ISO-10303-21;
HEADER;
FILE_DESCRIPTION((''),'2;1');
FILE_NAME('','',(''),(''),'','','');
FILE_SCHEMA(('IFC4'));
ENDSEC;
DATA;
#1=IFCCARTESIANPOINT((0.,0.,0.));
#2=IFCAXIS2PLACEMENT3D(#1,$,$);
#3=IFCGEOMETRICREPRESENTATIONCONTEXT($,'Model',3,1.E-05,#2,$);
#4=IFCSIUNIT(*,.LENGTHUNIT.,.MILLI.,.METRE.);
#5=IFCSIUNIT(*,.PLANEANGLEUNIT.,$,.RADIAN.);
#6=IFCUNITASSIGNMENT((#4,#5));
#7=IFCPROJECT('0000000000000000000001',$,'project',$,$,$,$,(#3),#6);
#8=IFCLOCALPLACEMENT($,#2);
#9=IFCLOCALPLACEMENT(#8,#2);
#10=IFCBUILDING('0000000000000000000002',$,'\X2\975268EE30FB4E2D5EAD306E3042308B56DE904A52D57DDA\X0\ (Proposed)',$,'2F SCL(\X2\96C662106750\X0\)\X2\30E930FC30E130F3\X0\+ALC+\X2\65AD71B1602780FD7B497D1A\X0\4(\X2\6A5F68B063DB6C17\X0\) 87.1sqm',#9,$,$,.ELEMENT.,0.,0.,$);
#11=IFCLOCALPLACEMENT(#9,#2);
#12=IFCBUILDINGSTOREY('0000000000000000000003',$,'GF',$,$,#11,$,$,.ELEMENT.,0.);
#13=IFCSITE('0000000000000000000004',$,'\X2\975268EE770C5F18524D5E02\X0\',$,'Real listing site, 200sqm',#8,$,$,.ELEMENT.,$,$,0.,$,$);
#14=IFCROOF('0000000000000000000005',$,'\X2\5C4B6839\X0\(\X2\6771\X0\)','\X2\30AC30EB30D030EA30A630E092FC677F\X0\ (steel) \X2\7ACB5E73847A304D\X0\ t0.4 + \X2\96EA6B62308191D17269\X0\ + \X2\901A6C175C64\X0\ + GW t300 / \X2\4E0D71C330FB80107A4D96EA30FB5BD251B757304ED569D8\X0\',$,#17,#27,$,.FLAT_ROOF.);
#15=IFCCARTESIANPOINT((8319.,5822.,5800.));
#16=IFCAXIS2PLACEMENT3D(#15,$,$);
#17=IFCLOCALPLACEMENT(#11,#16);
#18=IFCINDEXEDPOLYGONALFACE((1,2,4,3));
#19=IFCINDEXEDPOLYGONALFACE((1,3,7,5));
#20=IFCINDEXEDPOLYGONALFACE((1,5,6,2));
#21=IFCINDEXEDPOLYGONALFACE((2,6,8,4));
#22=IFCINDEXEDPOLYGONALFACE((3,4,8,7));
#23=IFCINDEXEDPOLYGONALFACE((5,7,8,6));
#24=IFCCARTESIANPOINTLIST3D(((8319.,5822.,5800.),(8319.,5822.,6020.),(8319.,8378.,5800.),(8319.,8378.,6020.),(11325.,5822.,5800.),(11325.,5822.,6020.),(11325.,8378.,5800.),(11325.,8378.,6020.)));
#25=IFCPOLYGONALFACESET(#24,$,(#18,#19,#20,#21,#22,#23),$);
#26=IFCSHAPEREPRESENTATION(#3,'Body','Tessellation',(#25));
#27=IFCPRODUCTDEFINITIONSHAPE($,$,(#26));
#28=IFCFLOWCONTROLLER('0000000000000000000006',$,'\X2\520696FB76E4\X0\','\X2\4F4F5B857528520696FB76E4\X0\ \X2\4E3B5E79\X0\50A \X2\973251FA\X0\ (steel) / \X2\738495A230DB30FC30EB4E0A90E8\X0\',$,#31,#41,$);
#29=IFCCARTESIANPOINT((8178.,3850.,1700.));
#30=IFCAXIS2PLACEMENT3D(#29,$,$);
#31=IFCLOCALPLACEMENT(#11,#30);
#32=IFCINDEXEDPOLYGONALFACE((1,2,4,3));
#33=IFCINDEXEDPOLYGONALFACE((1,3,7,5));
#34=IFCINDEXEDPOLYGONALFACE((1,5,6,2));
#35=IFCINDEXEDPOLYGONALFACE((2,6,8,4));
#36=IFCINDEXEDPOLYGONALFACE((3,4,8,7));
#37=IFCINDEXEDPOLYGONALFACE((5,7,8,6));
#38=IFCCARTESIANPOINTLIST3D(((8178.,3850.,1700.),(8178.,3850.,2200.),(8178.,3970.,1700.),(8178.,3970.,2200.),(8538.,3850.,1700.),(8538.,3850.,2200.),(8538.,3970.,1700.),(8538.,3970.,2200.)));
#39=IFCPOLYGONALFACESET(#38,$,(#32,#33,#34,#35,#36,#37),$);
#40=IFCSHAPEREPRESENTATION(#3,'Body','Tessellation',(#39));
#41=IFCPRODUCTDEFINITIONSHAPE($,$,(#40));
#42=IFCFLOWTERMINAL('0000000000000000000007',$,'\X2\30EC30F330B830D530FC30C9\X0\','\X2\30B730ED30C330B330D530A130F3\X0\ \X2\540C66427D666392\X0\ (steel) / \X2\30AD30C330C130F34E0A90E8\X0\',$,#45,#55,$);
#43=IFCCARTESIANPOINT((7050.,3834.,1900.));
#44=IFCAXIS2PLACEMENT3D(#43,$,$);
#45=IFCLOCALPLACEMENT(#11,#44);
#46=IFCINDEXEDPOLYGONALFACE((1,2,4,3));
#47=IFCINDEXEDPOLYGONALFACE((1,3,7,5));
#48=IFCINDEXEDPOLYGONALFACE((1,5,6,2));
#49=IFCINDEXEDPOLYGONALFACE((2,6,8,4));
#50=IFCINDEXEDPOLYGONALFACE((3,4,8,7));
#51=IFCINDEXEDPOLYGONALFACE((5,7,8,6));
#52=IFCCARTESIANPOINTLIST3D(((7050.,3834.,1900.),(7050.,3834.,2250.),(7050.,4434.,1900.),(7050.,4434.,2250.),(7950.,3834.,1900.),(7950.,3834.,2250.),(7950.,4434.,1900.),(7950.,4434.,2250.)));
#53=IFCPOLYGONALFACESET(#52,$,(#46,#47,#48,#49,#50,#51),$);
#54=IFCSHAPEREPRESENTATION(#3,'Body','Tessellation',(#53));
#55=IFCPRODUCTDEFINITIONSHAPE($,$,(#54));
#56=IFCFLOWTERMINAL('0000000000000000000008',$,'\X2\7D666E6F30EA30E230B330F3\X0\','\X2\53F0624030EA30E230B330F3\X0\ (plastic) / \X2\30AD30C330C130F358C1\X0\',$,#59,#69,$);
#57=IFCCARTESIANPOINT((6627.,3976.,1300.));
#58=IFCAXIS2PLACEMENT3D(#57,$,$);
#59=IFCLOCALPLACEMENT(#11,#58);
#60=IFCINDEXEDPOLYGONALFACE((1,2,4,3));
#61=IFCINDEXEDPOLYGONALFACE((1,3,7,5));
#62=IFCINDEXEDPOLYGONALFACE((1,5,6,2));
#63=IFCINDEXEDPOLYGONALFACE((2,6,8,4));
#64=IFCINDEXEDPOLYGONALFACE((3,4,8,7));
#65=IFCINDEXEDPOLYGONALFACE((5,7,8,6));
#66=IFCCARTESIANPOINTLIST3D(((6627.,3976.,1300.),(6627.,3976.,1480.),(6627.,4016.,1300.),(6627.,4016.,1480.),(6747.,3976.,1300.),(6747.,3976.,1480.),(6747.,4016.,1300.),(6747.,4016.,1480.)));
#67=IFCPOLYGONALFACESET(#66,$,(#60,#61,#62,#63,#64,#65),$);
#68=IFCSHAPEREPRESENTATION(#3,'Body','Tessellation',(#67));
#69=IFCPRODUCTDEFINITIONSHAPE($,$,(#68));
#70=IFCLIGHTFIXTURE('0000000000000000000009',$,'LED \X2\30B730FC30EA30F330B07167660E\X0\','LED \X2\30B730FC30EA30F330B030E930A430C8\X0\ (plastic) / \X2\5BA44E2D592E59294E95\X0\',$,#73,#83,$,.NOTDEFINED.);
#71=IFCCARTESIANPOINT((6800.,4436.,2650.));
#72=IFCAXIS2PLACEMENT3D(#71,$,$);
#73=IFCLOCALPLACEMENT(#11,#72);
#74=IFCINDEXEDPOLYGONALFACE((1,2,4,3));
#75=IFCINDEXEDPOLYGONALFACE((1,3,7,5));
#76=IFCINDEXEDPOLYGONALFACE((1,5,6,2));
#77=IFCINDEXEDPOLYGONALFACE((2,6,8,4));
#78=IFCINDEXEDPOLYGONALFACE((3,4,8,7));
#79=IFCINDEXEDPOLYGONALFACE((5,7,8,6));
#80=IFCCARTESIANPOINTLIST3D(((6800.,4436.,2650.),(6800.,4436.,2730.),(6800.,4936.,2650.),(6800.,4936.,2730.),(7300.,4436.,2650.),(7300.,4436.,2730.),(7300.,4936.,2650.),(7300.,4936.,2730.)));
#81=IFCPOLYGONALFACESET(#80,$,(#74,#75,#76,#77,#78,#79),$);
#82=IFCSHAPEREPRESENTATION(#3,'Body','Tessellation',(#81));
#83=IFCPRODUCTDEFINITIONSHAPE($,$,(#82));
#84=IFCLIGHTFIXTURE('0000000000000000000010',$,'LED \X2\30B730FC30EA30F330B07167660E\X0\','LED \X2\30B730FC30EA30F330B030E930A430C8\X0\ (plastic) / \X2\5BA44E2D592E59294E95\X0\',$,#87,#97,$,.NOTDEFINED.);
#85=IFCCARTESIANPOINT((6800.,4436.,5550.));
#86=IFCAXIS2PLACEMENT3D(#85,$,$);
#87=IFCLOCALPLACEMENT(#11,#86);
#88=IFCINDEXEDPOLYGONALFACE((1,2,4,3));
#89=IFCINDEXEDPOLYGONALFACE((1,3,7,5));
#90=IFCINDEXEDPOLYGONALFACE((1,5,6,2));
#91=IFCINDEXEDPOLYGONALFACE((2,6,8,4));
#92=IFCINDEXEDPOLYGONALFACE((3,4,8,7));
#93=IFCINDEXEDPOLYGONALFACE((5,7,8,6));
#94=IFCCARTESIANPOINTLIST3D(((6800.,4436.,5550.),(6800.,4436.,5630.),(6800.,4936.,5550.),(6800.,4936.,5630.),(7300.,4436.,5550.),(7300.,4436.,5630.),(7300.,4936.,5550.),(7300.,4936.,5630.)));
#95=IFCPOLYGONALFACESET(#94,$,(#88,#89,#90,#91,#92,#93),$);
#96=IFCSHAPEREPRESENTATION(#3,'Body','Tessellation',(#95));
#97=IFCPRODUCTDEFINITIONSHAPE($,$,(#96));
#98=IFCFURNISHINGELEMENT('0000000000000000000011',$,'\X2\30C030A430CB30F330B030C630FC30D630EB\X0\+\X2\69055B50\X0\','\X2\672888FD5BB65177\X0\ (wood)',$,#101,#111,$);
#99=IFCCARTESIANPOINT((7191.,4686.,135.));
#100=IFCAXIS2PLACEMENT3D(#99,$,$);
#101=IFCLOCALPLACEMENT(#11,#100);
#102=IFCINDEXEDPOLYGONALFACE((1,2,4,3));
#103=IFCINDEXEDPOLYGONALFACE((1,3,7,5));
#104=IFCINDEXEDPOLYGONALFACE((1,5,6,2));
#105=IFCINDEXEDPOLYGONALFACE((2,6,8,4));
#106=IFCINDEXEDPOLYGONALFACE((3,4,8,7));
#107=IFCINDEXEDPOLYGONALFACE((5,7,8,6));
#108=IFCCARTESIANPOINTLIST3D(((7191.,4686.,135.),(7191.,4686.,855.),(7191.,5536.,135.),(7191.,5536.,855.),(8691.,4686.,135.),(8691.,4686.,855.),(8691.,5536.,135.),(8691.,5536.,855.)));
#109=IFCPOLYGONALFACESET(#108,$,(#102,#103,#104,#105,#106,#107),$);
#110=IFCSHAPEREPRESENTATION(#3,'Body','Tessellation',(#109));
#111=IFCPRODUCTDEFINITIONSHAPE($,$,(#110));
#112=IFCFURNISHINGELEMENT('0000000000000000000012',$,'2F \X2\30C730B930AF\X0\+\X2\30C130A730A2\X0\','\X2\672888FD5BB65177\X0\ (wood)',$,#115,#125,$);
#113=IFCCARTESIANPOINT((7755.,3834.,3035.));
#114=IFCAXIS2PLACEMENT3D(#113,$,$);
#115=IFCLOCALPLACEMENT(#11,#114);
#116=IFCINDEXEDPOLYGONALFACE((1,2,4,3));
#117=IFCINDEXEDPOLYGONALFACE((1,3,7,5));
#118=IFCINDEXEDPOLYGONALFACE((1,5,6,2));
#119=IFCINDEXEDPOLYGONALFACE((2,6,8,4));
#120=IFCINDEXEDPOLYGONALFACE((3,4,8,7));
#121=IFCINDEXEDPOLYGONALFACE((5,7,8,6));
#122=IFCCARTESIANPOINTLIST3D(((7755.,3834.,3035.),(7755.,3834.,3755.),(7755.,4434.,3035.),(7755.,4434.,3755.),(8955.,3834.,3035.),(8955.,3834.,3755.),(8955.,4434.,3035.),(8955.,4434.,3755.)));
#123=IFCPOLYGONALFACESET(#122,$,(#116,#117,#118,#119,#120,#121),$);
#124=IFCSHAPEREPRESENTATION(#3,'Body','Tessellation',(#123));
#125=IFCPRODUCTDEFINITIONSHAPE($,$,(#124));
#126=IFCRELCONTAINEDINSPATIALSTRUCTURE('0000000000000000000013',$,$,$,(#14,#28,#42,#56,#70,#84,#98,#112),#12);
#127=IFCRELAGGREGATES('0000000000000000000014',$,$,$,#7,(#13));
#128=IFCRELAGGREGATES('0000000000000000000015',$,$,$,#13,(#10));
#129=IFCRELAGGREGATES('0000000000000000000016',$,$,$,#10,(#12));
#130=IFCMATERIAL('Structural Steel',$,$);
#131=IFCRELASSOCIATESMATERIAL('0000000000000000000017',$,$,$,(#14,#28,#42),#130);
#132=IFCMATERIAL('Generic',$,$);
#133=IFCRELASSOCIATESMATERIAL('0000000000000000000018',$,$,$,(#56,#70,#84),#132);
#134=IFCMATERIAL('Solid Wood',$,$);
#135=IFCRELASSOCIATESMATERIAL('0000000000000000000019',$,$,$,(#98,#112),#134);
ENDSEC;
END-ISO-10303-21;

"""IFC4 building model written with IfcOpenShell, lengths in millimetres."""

from ifc_helpers import new_model, si_unit, frame, frame_2d, origin, place, context, project, spatial, rectangle, extrude, material, element, save


model = new_model("IFC4")

# Units and contexts
model_context = context("Model", 3, precision=1e-05, world=origin())
ifc_project = project(units=[si_unit("LENGTHUNIT", "METRE", prefix="MILLI"), si_unit("PLANEANGLEUNIT", "RADIAN")], contexts=[model_context])

# Site, building, storey
site_placement = place(None, origin())
site = spatial("IfcSite", under=ifc_project, at=site_placement, Name="青森県弘前市", ObjectType="Real listing site, 200sqm", CompositionType="ELEMENT", RefElevation=0.0)
building_placement = place(site_placement, origin())
building = spatial("IfcBuilding", under=site, at=building_placement, Name="青森・中庭のある回遊動線 (Proposed)", ObjectType="2F SCL(集成材)ラーメン+ALC+断熱性能等級4(機械換気) 87.1sqm", CompositionType="ELEMENT", ElevationOfRefHeight=0.0, ElevationOfTerrain=0.0)
storey_placement = place(building_placement, origin())
storey = spatial("IfcBuildingStorey", under=building, at=storey_placement, Name="GF", CompositionType="ELEMENT", Elevation=0.0)

# Shared definitions
ifc_material_1 = material(Name="Solid Wood")

# Roof
ifc_material_2 = material(Name="Structural Steel")
for number, where, name in (
    (1, (8319.0, 5822.0, 5800.0), "屋根(東)"),
):
    element("IfcRoof", number, at=place(storey_placement, frame(where)), inside=storey, material=ifc_material_2, Name=name, Description="ガルバリウム鋼板 (steel) 立平葺き t0.4 + 雪止め金物 + 通気層 + GW t300 / 不燃・耐積雪・寒冷地仕様", PredefinedType="FLAT_ROOF", context=model_context, shape_type="SweptSolid", body=[
        extrude(rectangle(XDim=3006.0, YDim=2556.0, at=frame_2d((1503.0, 1278.0))), frame((8319.0, 5822.0, 5800.0)), (0.0, 0.0, 1.0), 220.0),
    ])

# Flow controller
flow_controller_placement = place(storey_placement, frame((8178.0, 3850.0, 1700.0)))
element("IfcFlowController", 2, at=flow_controller_placement, inside=storey, material=ifc_material_2, Name="分電盤", Description="住宅用分電盤 主幹50A 露出 (steel) / 玄関ホール上部", context=model_context, shape_type="SweptSolid", body=[
    extrude(rectangle(XDim=360.0, YDim=120.0, at=frame_2d((180.0, 60.0))), frame((8178.0, 3850.0, 1700.0)), (0.0, 0.0, 1.0), 500.0),
])

# Flow terminals
flow_terminal_1_placement = place(storey_placement, frame((7050.0, 3834.0, 1900.0)))
element("IfcFlowTerminal", 3, at=flow_terminal_1_placement, inside=storey, material=ifc_material_2, Name="レンジフード", Description="シロッコファン 同時給排 (steel) / キッチン上部", context=model_context, shape_type="SweptSolid", body=[
    extrude(rectangle(XDim=900.0, YDim=600.0, at=frame_2d((450.0, 300.0))), frame((7050.0, 3834.0, 1900.0)), (0.0, 0.0, 1.0), 350.0),
])
ifc_material_3 = material(Name="Generic")
flow_terminal_2_placement = place(storey_placement, frame((6627.0, 3976.0, 1300.0)))
element("IfcFlowTerminal", 4, at=flow_terminal_2_placement, inside=storey, material=ifc_material_3, Name="給湯リモコン", Description="台所リモコン (plastic) / キッチン壁", context=model_context, shape_type="SweptSolid", body=[
    extrude(rectangle(XDim=120.0, YDim=40.0, at=frame_2d((60.0, 20.0))), frame((6627.0, 3976.0, 1300.0)), (0.0, 0.0, 1.0), 180.0),
])

# Light fixtures
light_fixture_1_placement = place(storey_placement, frame((6800.0, 4436.0, 2650.0)))
element("IfcLightFixture", 5, at=light_fixture_1_placement, inside=storey, material=ifc_material_3, Name="LED シーリング照明", Description="LED シーリングライト (plastic) / 室中央天井", PredefinedType="NOTDEFINED", context=model_context, shape_type="SweptSolid", body=[
    extrude(rectangle(XDim=500.0, YDim=500.0, at=frame_2d((250.0, 250.0))), frame((6800.0, 4436.0, 2650.0)), (0.0, 0.0, 1.0), 80.0),
])
light_fixture_2_placement = place(storey_placement, frame((6800.0, 4436.0, 5550.0)))
element("IfcLightFixture", 6, at=light_fixture_2_placement, inside=storey, material=ifc_material_3, Name="LED シーリング照明", Description="LED シーリングライト (plastic) / 室中央天井", PredefinedType="NOTDEFINED", context=model_context, shape_type="SweptSolid", body=[
    extrude(rectangle(XDim=500.0, YDim=500.0, at=frame_2d((250.0, 250.0))), frame((6800.0, 4436.0, 5550.0)), (0.0, 0.0, 1.0), 80.0),
])

# Furnishing elements
furnishing_1_placement = place(storey_placement, frame((7191.0, 4686.0, 135.0)))
element("IfcFurnishingElement", 7, at=furnishing_1_placement, inside=storey, material=ifc_material_1, Name="ダイニングテーブル+椅子", Description="木製家具 (wood)", context=model_context, shape_type="SweptSolid", body=[
    extrude(rectangle(XDim=1500.0, YDim=850.0, at=frame_2d((750.0, 425.0))), frame((7191.0, 4686.0, 135.0)), (0.0, 0.0, 1.0), 720.0),
])
furnishing_2_placement = place(storey_placement, frame((7755.0, 3834.0, 3035.0)))
element("IfcFurnishingElement", 8, at=furnishing_2_placement, inside=storey, material=ifc_material_1, Name="2F デスク+チェア", Description="木製家具 (wood)", context=model_context, shape_type="SweptSolid", body=[
    extrude(rectangle(XDim=1200.0, YDim=600.0, at=frame_2d((600.0, 300.0))), frame((7755.0, 3834.0, 3035.0)), (0.0, 0.0, 1.0), 720.0),
])

save(model, "model.ifc")
